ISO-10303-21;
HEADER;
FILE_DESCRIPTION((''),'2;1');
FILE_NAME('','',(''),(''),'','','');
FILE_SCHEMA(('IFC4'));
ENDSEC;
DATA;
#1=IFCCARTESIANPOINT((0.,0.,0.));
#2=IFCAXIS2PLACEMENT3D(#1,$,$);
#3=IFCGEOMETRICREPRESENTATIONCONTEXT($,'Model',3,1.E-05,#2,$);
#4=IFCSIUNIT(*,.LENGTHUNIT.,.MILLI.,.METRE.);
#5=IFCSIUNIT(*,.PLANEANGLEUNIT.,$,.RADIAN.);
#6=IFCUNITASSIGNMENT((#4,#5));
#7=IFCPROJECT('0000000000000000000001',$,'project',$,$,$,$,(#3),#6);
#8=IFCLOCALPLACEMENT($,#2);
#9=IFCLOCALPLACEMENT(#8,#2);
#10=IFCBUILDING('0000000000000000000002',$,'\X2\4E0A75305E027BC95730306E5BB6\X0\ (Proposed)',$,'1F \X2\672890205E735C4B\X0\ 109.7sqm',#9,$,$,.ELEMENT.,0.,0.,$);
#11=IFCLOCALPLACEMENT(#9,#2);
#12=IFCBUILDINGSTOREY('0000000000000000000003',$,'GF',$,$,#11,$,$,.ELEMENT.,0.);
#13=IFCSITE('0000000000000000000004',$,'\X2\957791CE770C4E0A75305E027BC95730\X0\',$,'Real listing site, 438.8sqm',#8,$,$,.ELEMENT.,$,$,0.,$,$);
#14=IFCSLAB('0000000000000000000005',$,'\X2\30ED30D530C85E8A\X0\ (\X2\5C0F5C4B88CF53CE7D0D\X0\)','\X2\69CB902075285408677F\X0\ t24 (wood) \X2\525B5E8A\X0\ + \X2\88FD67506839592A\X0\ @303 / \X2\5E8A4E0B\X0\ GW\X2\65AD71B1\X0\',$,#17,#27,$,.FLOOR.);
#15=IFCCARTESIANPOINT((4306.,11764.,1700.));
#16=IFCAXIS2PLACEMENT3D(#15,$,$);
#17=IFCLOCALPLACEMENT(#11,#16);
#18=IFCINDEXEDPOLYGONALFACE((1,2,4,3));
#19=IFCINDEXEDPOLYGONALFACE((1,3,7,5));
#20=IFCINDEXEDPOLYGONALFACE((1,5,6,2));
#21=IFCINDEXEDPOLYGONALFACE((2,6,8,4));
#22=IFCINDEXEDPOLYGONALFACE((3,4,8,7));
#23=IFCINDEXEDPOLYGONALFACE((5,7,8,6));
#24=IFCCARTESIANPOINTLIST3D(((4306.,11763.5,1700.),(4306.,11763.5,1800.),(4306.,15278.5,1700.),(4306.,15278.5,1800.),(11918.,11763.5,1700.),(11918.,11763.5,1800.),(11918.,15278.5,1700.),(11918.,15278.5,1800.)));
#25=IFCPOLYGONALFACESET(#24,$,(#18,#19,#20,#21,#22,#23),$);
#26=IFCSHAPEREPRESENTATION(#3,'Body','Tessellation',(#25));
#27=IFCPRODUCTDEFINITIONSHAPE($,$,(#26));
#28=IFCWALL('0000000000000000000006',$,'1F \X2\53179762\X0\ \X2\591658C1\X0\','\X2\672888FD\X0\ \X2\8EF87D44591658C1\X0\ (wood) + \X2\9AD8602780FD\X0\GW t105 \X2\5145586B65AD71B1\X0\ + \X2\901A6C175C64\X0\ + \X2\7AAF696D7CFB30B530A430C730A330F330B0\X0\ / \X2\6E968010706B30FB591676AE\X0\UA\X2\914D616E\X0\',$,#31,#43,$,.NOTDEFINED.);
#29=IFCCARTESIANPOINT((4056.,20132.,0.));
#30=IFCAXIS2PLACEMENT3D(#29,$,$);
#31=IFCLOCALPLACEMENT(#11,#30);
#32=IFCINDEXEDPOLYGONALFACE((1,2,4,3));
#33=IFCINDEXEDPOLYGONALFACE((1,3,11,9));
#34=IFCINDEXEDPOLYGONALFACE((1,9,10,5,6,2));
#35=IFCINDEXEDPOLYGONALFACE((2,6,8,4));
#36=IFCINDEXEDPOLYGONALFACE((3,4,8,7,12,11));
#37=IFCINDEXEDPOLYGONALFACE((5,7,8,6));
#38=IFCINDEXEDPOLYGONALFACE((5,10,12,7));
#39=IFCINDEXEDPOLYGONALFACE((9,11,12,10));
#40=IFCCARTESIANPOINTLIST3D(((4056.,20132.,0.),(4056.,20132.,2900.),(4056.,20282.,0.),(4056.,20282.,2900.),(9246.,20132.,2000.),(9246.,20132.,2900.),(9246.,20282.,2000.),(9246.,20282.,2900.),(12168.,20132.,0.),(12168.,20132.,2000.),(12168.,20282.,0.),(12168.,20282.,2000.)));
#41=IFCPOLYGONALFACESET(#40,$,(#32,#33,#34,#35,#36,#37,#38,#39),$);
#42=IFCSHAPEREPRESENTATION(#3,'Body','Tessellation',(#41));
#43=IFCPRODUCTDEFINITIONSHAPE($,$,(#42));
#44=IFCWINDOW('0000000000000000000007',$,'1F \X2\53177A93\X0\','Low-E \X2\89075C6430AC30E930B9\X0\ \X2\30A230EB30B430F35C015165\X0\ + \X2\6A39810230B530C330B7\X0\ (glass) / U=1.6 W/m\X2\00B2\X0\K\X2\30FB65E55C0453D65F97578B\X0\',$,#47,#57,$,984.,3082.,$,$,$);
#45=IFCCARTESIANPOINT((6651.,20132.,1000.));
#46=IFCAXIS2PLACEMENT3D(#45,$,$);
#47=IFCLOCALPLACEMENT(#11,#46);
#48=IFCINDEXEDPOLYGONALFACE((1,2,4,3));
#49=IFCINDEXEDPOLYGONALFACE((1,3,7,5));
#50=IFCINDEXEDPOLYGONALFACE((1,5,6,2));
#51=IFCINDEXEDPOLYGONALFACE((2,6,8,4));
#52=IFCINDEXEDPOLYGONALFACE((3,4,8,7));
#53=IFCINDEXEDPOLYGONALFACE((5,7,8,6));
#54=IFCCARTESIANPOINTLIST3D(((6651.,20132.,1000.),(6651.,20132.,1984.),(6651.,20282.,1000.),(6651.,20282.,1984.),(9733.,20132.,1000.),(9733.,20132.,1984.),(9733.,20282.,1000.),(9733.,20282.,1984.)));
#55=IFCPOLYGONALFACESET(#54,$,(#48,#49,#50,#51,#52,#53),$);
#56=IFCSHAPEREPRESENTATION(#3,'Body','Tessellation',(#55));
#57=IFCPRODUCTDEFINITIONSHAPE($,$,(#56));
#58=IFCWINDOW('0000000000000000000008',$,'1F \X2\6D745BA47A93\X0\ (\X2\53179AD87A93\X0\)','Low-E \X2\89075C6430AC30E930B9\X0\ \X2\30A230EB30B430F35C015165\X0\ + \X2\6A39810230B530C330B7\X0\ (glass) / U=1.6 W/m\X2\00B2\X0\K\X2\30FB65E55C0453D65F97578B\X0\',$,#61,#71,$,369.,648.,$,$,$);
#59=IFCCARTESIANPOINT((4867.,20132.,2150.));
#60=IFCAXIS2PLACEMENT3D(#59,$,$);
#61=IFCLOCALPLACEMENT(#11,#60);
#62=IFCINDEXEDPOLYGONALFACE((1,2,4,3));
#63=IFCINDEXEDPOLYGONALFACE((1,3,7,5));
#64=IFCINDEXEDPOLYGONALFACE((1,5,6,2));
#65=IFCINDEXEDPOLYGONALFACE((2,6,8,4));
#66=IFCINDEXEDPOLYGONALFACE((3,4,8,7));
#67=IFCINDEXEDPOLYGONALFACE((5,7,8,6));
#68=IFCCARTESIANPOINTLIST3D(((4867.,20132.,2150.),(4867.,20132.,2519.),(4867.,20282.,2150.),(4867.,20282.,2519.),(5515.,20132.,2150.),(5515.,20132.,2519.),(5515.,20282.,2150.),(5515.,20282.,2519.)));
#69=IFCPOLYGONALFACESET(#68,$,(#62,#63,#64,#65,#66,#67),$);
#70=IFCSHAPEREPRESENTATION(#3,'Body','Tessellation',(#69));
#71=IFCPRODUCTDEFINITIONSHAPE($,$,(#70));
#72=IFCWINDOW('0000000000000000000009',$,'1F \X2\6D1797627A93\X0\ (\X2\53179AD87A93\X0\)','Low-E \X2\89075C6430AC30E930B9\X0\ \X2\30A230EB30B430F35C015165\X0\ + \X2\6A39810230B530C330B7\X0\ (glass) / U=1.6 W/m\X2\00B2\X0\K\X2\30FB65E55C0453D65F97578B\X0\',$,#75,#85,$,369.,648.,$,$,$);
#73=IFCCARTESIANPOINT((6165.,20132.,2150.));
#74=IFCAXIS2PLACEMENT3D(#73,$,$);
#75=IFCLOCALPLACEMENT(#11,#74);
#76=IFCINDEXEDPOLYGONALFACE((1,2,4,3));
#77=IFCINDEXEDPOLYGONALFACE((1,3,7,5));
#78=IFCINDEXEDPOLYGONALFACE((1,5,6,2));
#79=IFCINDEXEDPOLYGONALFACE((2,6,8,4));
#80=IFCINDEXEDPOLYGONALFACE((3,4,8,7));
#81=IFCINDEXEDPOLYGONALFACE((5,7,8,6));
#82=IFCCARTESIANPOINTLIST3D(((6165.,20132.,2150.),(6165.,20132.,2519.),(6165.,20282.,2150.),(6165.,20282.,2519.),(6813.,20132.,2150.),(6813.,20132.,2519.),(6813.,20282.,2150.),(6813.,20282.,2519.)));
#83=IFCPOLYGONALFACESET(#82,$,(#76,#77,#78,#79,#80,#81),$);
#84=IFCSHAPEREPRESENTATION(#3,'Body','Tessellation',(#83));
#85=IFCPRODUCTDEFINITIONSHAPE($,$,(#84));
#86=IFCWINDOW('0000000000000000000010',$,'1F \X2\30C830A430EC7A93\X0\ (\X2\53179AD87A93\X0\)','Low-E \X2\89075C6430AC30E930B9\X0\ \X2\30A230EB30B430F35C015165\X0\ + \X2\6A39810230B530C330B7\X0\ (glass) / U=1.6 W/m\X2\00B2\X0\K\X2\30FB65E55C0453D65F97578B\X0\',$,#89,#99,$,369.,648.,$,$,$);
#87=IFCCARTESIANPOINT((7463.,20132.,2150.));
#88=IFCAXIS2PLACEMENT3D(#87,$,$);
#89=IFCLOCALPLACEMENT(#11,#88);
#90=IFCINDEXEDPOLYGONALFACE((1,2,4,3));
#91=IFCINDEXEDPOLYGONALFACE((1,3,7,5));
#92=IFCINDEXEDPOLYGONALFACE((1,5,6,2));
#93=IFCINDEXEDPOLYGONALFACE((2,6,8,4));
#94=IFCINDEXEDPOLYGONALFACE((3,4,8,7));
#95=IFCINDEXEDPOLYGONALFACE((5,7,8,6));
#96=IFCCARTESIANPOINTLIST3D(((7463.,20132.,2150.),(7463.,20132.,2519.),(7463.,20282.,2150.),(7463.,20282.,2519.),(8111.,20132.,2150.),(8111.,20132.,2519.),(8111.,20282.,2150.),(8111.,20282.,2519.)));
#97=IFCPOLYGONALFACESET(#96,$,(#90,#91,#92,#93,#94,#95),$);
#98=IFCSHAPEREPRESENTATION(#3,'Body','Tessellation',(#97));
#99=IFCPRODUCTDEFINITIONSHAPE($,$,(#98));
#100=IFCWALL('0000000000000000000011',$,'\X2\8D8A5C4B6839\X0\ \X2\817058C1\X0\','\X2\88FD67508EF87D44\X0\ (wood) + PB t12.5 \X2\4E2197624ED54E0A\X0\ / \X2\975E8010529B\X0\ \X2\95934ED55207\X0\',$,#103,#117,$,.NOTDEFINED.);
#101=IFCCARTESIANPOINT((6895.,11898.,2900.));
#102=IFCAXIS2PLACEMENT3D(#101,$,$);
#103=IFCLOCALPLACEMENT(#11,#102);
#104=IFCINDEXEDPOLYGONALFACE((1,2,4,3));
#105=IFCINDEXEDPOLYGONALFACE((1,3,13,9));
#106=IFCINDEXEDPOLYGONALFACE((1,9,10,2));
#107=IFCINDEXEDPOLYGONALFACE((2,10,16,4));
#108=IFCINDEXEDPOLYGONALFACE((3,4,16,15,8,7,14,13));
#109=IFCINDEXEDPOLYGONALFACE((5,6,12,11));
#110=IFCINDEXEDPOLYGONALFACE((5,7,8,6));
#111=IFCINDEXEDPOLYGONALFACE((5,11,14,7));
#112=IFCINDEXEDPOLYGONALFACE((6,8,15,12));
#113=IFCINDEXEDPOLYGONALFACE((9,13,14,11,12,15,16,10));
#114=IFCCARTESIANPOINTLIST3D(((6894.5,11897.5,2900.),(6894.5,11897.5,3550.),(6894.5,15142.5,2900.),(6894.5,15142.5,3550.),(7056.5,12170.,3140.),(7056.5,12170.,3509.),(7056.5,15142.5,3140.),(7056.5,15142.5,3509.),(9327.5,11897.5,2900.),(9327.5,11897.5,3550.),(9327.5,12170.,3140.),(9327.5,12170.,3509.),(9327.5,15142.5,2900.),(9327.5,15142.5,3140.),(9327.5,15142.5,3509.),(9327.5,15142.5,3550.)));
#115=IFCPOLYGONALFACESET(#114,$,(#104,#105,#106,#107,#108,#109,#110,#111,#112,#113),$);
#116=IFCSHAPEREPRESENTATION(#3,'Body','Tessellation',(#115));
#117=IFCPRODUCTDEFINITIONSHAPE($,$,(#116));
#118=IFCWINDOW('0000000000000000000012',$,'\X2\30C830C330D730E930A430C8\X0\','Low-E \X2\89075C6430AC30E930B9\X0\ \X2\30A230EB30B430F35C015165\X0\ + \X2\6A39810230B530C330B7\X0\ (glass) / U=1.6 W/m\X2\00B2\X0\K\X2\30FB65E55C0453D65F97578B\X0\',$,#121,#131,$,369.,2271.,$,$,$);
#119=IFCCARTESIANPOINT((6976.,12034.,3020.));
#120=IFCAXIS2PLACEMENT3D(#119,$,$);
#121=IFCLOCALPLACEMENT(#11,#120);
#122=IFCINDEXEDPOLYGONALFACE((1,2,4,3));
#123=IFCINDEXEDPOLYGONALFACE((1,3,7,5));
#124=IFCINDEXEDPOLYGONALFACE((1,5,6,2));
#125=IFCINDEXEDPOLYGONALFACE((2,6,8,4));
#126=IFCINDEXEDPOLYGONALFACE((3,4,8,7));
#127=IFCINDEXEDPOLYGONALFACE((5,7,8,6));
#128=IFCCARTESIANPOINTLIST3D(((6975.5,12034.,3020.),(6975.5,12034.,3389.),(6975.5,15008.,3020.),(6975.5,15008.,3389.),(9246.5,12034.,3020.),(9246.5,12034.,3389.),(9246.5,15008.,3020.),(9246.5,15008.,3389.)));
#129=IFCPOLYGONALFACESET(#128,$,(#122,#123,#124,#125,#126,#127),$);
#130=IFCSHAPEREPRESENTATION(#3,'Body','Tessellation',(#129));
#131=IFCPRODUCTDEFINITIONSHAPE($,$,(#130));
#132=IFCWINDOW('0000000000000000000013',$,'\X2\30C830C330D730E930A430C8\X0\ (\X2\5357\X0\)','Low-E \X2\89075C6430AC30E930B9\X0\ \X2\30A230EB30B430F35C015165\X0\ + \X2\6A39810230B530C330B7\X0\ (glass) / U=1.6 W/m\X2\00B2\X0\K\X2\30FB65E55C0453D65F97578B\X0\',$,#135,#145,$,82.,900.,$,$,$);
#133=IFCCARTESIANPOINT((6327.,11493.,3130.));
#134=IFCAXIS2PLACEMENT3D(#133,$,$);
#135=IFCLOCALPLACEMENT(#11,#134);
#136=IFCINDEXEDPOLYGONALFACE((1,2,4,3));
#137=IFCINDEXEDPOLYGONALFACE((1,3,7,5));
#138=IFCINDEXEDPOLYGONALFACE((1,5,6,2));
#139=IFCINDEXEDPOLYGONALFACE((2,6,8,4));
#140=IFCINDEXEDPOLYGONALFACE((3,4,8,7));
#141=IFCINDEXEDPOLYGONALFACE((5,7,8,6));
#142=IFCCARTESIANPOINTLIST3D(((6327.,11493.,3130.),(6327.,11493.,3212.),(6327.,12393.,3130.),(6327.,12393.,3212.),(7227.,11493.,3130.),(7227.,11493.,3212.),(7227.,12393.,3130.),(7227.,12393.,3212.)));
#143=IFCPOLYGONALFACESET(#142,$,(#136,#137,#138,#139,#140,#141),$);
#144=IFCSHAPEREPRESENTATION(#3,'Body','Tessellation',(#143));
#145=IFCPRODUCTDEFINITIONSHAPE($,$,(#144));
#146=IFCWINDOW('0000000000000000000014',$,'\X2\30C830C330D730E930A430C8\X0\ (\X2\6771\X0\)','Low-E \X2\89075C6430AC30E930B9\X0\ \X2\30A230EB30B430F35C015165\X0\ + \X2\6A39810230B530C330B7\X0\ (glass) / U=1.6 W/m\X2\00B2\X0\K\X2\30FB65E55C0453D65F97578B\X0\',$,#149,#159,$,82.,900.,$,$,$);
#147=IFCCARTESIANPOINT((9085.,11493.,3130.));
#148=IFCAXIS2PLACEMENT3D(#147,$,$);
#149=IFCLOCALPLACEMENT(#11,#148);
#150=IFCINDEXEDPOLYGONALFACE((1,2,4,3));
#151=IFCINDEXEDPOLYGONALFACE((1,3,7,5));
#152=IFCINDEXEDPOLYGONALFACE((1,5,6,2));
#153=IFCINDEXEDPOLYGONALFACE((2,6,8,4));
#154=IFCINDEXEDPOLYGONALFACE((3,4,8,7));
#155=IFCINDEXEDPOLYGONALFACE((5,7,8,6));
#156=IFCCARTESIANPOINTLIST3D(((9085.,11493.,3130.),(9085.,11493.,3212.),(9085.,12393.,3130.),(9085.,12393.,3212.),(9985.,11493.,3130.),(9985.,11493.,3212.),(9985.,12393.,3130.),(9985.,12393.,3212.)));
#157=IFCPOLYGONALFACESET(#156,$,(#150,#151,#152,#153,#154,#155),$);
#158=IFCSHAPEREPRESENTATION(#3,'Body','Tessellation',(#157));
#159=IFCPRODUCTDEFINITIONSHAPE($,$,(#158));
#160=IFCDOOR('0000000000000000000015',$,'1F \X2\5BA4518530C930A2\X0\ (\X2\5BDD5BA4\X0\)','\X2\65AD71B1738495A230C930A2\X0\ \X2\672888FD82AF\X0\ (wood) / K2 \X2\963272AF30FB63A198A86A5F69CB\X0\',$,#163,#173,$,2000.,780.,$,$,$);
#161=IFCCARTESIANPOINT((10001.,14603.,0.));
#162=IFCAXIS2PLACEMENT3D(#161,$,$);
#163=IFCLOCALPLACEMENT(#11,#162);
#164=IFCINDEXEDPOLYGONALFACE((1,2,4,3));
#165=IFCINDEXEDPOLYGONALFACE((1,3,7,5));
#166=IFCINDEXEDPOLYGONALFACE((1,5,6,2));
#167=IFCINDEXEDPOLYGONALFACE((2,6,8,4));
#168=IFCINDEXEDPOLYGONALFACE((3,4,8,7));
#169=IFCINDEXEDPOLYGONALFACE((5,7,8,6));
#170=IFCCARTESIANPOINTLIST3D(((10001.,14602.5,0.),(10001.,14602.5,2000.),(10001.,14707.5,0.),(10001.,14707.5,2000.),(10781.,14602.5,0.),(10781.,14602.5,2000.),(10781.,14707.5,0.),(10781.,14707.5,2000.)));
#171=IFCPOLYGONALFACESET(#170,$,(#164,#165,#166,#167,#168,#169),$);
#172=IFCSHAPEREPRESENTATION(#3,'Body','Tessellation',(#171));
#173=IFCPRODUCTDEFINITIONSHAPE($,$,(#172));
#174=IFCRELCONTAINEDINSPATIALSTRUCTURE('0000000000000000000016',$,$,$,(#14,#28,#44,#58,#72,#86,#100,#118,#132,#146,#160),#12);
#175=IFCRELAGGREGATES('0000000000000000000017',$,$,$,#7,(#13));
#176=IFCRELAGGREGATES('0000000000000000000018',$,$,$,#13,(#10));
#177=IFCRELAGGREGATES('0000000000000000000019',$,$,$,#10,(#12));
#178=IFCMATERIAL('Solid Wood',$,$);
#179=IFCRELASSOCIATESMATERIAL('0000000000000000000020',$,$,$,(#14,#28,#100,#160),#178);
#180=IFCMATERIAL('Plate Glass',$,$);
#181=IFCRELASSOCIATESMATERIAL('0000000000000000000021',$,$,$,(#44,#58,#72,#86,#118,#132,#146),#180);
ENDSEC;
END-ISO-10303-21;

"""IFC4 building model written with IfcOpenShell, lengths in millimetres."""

from ifc_helpers import new_model, si_unit, frame, frame_2d, origin, place, context, project, spatial, rectangle, extrude, material, element, fill, save


model = new_model("IFC4")

# Units and contexts
model_context = context("Model", 3, precision=1e-05, world=origin())
ifc_project = project(units=[si_unit("LENGTHUNIT", "METRE", prefix="MILLI"), si_unit("PLANEANGLEUNIT", "RADIAN")], contexts=[model_context])

# Site, building, storey
site_placement = place(None, origin())
site = spatial("IfcSite", under=ifc_project, at=site_placement, Name="長野県上田市築地", ObjectType="Real listing site, 438.8sqm", CompositionType="ELEMENT", RefElevation=0.0)
building_placement = place(site_placement, origin())
building = spatial("IfcBuilding", under=site, at=building_placement, Name="上田市築地の家 (Proposed)", ObjectType="1F 木造平屋 109.7sqm", CompositionType="ELEMENT", ElevationOfRefHeight=0.0, ElevationOfTerrain=0.0)
storey_placement = place(building_placement, origin())
storey = spatial("IfcBuildingStorey", under=building, at=storey_placement, Name="GF", CompositionType="ELEMENT", Elevation=0.0)

# Slab
ifc_material_1 = material(Name="Solid Wood")
slab_placement = place(storey_placement, frame((4306.0, 11764.0, 1700.0)))
element("IfcSlab", 1, at=slab_placement, inside=storey, material=ifc_material_1, Name="ロフト床 (小屋裏収納)", Description="構造用合板 t24 (wood) 剛床 + 製材根太 @303 / 床下 GW断熱", PredefinedType="FLOOR", context=model_context, shape_type="SweptSolid", body=[
    extrude(rectangle(XDim=7612.0, YDim=3515.0, at=frame_2d((3806.0, 1757.0))), frame((4306.0, 11764.0, 1700.0)), (0.0, 0.0, 1.0), 100.0),
])

# Wall, openings, windows
wall_1_placement = place(storey_placement, frame((4056.0, 20132.0, 0.0)))
wall_1 = element("IfcWall", 2, at=wall_1_placement, inside=storey, material=ifc_material_1, Name="1F 北面 外壁", Description="木製 軸組外壁 (wood) + 高性能GW t105 充填断熱 + 通気層 + 窯業系サイディング / 準耐火・外皮UA配慮", PredefinedType="NOTDEFINED", context=model_context, shape_type="SweptSolid", body=[
    extrude(rectangle(XDim=8112.0, YDim=150.0, at=frame_2d((4056.0, 75.0))), frame((4056.0, 20132.0, 0.0)), (0.0, 0.0, 1.0), 2900.0),
])
opening_1_placement = place(storey_placement, frame((6651.0, 20132.0, 1000.0)))
opening_1 = element("IfcOpeningElement", 3, at=opening_1_placement, cuts=wall_1, PredefinedType="NOTDEFINED", context=model_context, shape_type="SweptSolid", body=[
    extrude(rectangle(XDim=3082.0, YDim=150.0, at=frame_2d((1541.0, 75.0))), frame((6651.0, 20132.0, 1000.0)), (0.0, 0.0, 1.0), 984.0),
])
opening_2_placement = place(storey_placement, frame((4867.0, 20132.0, 2150.0)))
opening_2 = element("IfcOpeningElement", 4, at=opening_2_placement, cuts=wall_1, PredefinedType="NOTDEFINED", context=model_context, shape_type="SweptSolid", body=[
    extrude(rectangle(XDim=648.0, YDim=150.0, at=frame_2d((324.0, 75.0))), frame((4867.0, 20132.0, 2150.0)), (0.0, 0.0, 1.0), 369.0),
])
opening_3_placement = place(storey_placement, frame((6165.0, 20132.0, 2150.0)))
opening_3 = element("IfcOpeningElement", 5, at=opening_3_placement, cuts=wall_1, PredefinedType="NOTDEFINED", context=model_context, shape_type="SweptSolid", body=[
    extrude(rectangle(XDim=648.0, YDim=150.0, at=frame_2d((324.0, 75.0))), frame((6165.0, 20132.0, 2150.0)), (0.0, 0.0, 1.0), 369.0),
])
opening_4_placement = place(storey_placement, frame((7463.0, 20132.0, 2150.0)))
opening_4 = element("IfcOpeningElement", 6, at=opening_4_placement, cuts=wall_1, PredefinedType="NOTDEFINED", context=model_context, shape_type="SweptSolid", body=[
    extrude(rectangle(XDim=648.0, YDim=150.0, at=frame_2d((324.0, 75.0))), frame((7463.0, 20132.0, 2150.0)), (0.0, 0.0, 1.0), 369.0),
])
ifc_material_2 = material(Name="Plate Glass")
window_1_placement = place(storey_placement, frame((6651.0, 20132.0, 1000.0)))
window_1 = element("IfcWindow", 7, at=window_1_placement, inside=storey, material=ifc_material_2, Name="1F 北窓", Description="Low-E 複層ガラス アルゴン封入 + 樹脂サッシ (glass) / U=1.6 W/m²K・日射取得型", OverallHeight=984.0, OverallWidth=3082.0, context=model_context, shape_type="SweptSolid", body=[
    extrude(rectangle(XDim=3082.0, YDim=150.0, at=frame_2d((1541.0, 75.0))), frame((6651.0, 20132.0, 1000.0)), (0.0, 0.0, 1.0), 984.0),
])
fill(opening_1, window_1)
window_2_placement = place(storey_placement, frame((4867.0, 20132.0, 2150.0)))
window_2 = element("IfcWindow", 8, at=window_2_placement, inside=storey, material=ifc_material_2, Name="1F 浴室窓 (北高窓)", Description="Low-E 複層ガラス アルゴン封入 + 樹脂サッシ (glass) / U=1.6 W/m²K・日射取得型", OverallHeight=369.0, OverallWidth=648.0, context=model_context, shape_type="SweptSolid", body=[
    extrude(rectangle(XDim=648.0, YDim=150.0, at=frame_2d((324.0, 75.0))), frame((4867.0, 20132.0, 2150.0)), (0.0, 0.0, 1.0), 369.0),
])
fill(opening_2, window_2)
window_3_placement = place(storey_placement, frame((6165.0, 20132.0, 2150.0)))
window_3 = element("IfcWindow", 9, at=window_3_placement, inside=storey, material=ifc_material_2, Name="1F 洗面窓 (北高窓)", Description="Low-E 複層ガラス アルゴン封入 + 樹脂サッシ (glass) / U=1.6 W/m²K・日射取得型", OverallHeight=369.0, OverallWidth=648.0, context=model_context, shape_type="SweptSolid", body=[
    extrude(rectangle(XDim=648.0, YDim=150.0, at=frame_2d((324.0, 75.0))), frame((6165.0, 20132.0, 2150.0)), (0.0, 0.0, 1.0), 369.0),
])
fill(opening_3, window_3)
window_4_placement = place(storey_placement, frame((7463.0, 20132.0, 2150.0)))
window_4 = element("IfcWindow", 10, at=window_4_placement, inside=storey, material=ifc_material_2, Name="1F トイレ窓 (北高窓)", Description="Low-E 複層ガラス アルゴン封入 + 樹脂サッシ (glass) / U=1.6 W/m²K・日射取得型", OverallHeight=369.0, OverallWidth=648.0, context=model_context, shape_type="SweptSolid", body=[
    extrude(rectangle(XDim=648.0, YDim=150.0, at=frame_2d((324.0, 75.0))), frame((7463.0, 20132.0, 2150.0)), (0.0, 0.0, 1.0), 369.0),
])
fill(opening_4, window_4)

# Wall, openings, windows
wall_2_placement = place(storey_placement, frame((6895.0, 11898.0, 2900.0)))
wall_2 = element("IfcWall", 11, at=wall_2_placement, inside=storey, material=ifc_material_1, Name="越屋根 腰壁", Description="製材軸組 (wood) + PB t12.5 両面仕上 / 非耐力 間仕切", PredefinedType="NOTDEFINED", context=model_context, shape_type="SweptSolid", body=[
    extrude(rectangle(XDim=2433.0, YDim=3245.0, at=frame_2d((1216.0, 1622.0))), frame((6895.0, 11898.0, 2900.0)), (0.0, 0.0, 1.0), 650.0),
])
opening_5_placement = place(storey_placement, frame((6976.0, 12034.0, 3020.0)))
opening_5 = element("IfcOpeningElement", 12, at=opening_5_placement, cuts=wall_2, PredefinedType="NOTDEFINED", context=model_context, shape_type="SweptSolid", body=[
    extrude(rectangle(XDim=2271.0, YDim=2974.0, at=frame_2d((1135.0, 1487.0))), frame((6976.0, 12034.0, 3020.0)), (0.0, 0.0, 1.0), 369.0),
])
opening_6_placement = place(storey_placement, frame((6327.0, 11493.0, 3130.0)))
opening_6 = element("IfcOpeningElement", 13, at=opening_6_placement, cuts=wall_2, PredefinedType="NOTDEFINED", context=model_context, shape_type="SweptSolid", body=[
    extrude(rectangle(XDim=900.0, YDim=900.0, at=frame_2d((450.0, 450.0))), frame((6327.0, 11493.0, 3130.0)), (0.0, 0.0, 1.0), 82.0),
])
opening_7_placement = place(storey_placement, frame((9085.0, 11493.0, 3130.0)))
opening_7 = element("IfcOpeningElement", 14, at=opening_7_placement, cuts=wall_2, PredefinedType="NOTDEFINED", context=model_context, shape_type="SweptSolid", body=[
    extrude(rectangle(XDim=900.0, YDim=900.0, at=frame_2d((450.0, 450.0))), frame((9085.0, 11493.0, 3130.0)), (0.0, 0.0, 1.0), 82.0),
])
window_5_placement = place(storey_placement, frame((6976.0, 12034.0, 3020.0)))
window_5 = element("IfcWindow", 15, at=window_5_placement, inside=storey, material=ifc_material_2, Name="トップライト", Description="Low-E 複層ガラス アルゴン封入 + 樹脂サッシ (glass) / U=1.6 W/m²K・日射取得型", OverallHeight=369.0, OverallWidth=2271.0, context=model_context, shape_type="SweptSolid", body=[
    extrude(rectangle(XDim=2271.0, YDim=2974.0, at=frame_2d((1135.0, 1487.0))), frame((6976.0, 12034.0, 3020.0)), (0.0, 0.0, 1.0), 369.0),
])
fill(opening_5, window_5)
window_6_placement = place(storey_placement, frame((6327.0, 11493.0, 3130.0)))
window_6 = element("IfcWindow", 16, at=window_6_placement, inside=storey, material=ifc_material_2, Name="トップライト (南)", Description="Low-E 複層ガラス アルゴン封入 + 樹脂サッシ (glass) / U=1.6 W/m²K・日射取得型", OverallHeight=82.0, OverallWidth=900.0, context=model_context, shape_type="SweptSolid", body=[
    extrude(rectangle(XDim=900.0, YDim=900.0, at=frame_2d((450.0, 450.0))), frame((6327.0, 11493.0, 3130.0)), (0.0, 0.0, 1.0), 82.0),
])
fill(opening_6, window_6)
window_7_placement = place(storey_placement, frame((9085.0, 11493.0, 3130.0)))
window_7 = element("IfcWindow", 17, at=window_7_placement, inside=storey, material=ifc_material_2, Name="トップライト (東)", Description="Low-E 複層ガラス アルゴン封入 + 樹脂サッシ (glass) / U=1.6 W/m²K・日射取得型", OverallHeight=82.0, OverallWidth=900.0, context=model_context, shape_type="SweptSolid", body=[
    extrude(rectangle(XDim=900.0, YDim=900.0, at=frame_2d((450.0, 450.0))), frame((9085.0, 11493.0, 3130.0)), (0.0, 0.0, 1.0), 82.0),
])
fill(opening_7, window_7)

# Door
door_1_placement = place(storey_placement, frame((10001.0, 14603.0, 0.0)))
element("IfcDoor", 18, at=door_1_placement, inside=storey, material=ifc_material_1, Name="1F 室内ドア (寝室)", Description="断熱玄関ドア 木製芯 (wood) / K2 防犯・採風機構", OverallHeight=2000.0, OverallWidth=780.0, context=model_context, shape_type="SweptSolid", body=[
    extrude(rectangle(XDim=780.0, YDim=105.0, at=frame_2d((390.0, 52.0))), frame((10001.0, 14603.0, 0.0)), (0.0, 0.0, 1.0), 2000.0),
])

save(model, "model.ifc")
